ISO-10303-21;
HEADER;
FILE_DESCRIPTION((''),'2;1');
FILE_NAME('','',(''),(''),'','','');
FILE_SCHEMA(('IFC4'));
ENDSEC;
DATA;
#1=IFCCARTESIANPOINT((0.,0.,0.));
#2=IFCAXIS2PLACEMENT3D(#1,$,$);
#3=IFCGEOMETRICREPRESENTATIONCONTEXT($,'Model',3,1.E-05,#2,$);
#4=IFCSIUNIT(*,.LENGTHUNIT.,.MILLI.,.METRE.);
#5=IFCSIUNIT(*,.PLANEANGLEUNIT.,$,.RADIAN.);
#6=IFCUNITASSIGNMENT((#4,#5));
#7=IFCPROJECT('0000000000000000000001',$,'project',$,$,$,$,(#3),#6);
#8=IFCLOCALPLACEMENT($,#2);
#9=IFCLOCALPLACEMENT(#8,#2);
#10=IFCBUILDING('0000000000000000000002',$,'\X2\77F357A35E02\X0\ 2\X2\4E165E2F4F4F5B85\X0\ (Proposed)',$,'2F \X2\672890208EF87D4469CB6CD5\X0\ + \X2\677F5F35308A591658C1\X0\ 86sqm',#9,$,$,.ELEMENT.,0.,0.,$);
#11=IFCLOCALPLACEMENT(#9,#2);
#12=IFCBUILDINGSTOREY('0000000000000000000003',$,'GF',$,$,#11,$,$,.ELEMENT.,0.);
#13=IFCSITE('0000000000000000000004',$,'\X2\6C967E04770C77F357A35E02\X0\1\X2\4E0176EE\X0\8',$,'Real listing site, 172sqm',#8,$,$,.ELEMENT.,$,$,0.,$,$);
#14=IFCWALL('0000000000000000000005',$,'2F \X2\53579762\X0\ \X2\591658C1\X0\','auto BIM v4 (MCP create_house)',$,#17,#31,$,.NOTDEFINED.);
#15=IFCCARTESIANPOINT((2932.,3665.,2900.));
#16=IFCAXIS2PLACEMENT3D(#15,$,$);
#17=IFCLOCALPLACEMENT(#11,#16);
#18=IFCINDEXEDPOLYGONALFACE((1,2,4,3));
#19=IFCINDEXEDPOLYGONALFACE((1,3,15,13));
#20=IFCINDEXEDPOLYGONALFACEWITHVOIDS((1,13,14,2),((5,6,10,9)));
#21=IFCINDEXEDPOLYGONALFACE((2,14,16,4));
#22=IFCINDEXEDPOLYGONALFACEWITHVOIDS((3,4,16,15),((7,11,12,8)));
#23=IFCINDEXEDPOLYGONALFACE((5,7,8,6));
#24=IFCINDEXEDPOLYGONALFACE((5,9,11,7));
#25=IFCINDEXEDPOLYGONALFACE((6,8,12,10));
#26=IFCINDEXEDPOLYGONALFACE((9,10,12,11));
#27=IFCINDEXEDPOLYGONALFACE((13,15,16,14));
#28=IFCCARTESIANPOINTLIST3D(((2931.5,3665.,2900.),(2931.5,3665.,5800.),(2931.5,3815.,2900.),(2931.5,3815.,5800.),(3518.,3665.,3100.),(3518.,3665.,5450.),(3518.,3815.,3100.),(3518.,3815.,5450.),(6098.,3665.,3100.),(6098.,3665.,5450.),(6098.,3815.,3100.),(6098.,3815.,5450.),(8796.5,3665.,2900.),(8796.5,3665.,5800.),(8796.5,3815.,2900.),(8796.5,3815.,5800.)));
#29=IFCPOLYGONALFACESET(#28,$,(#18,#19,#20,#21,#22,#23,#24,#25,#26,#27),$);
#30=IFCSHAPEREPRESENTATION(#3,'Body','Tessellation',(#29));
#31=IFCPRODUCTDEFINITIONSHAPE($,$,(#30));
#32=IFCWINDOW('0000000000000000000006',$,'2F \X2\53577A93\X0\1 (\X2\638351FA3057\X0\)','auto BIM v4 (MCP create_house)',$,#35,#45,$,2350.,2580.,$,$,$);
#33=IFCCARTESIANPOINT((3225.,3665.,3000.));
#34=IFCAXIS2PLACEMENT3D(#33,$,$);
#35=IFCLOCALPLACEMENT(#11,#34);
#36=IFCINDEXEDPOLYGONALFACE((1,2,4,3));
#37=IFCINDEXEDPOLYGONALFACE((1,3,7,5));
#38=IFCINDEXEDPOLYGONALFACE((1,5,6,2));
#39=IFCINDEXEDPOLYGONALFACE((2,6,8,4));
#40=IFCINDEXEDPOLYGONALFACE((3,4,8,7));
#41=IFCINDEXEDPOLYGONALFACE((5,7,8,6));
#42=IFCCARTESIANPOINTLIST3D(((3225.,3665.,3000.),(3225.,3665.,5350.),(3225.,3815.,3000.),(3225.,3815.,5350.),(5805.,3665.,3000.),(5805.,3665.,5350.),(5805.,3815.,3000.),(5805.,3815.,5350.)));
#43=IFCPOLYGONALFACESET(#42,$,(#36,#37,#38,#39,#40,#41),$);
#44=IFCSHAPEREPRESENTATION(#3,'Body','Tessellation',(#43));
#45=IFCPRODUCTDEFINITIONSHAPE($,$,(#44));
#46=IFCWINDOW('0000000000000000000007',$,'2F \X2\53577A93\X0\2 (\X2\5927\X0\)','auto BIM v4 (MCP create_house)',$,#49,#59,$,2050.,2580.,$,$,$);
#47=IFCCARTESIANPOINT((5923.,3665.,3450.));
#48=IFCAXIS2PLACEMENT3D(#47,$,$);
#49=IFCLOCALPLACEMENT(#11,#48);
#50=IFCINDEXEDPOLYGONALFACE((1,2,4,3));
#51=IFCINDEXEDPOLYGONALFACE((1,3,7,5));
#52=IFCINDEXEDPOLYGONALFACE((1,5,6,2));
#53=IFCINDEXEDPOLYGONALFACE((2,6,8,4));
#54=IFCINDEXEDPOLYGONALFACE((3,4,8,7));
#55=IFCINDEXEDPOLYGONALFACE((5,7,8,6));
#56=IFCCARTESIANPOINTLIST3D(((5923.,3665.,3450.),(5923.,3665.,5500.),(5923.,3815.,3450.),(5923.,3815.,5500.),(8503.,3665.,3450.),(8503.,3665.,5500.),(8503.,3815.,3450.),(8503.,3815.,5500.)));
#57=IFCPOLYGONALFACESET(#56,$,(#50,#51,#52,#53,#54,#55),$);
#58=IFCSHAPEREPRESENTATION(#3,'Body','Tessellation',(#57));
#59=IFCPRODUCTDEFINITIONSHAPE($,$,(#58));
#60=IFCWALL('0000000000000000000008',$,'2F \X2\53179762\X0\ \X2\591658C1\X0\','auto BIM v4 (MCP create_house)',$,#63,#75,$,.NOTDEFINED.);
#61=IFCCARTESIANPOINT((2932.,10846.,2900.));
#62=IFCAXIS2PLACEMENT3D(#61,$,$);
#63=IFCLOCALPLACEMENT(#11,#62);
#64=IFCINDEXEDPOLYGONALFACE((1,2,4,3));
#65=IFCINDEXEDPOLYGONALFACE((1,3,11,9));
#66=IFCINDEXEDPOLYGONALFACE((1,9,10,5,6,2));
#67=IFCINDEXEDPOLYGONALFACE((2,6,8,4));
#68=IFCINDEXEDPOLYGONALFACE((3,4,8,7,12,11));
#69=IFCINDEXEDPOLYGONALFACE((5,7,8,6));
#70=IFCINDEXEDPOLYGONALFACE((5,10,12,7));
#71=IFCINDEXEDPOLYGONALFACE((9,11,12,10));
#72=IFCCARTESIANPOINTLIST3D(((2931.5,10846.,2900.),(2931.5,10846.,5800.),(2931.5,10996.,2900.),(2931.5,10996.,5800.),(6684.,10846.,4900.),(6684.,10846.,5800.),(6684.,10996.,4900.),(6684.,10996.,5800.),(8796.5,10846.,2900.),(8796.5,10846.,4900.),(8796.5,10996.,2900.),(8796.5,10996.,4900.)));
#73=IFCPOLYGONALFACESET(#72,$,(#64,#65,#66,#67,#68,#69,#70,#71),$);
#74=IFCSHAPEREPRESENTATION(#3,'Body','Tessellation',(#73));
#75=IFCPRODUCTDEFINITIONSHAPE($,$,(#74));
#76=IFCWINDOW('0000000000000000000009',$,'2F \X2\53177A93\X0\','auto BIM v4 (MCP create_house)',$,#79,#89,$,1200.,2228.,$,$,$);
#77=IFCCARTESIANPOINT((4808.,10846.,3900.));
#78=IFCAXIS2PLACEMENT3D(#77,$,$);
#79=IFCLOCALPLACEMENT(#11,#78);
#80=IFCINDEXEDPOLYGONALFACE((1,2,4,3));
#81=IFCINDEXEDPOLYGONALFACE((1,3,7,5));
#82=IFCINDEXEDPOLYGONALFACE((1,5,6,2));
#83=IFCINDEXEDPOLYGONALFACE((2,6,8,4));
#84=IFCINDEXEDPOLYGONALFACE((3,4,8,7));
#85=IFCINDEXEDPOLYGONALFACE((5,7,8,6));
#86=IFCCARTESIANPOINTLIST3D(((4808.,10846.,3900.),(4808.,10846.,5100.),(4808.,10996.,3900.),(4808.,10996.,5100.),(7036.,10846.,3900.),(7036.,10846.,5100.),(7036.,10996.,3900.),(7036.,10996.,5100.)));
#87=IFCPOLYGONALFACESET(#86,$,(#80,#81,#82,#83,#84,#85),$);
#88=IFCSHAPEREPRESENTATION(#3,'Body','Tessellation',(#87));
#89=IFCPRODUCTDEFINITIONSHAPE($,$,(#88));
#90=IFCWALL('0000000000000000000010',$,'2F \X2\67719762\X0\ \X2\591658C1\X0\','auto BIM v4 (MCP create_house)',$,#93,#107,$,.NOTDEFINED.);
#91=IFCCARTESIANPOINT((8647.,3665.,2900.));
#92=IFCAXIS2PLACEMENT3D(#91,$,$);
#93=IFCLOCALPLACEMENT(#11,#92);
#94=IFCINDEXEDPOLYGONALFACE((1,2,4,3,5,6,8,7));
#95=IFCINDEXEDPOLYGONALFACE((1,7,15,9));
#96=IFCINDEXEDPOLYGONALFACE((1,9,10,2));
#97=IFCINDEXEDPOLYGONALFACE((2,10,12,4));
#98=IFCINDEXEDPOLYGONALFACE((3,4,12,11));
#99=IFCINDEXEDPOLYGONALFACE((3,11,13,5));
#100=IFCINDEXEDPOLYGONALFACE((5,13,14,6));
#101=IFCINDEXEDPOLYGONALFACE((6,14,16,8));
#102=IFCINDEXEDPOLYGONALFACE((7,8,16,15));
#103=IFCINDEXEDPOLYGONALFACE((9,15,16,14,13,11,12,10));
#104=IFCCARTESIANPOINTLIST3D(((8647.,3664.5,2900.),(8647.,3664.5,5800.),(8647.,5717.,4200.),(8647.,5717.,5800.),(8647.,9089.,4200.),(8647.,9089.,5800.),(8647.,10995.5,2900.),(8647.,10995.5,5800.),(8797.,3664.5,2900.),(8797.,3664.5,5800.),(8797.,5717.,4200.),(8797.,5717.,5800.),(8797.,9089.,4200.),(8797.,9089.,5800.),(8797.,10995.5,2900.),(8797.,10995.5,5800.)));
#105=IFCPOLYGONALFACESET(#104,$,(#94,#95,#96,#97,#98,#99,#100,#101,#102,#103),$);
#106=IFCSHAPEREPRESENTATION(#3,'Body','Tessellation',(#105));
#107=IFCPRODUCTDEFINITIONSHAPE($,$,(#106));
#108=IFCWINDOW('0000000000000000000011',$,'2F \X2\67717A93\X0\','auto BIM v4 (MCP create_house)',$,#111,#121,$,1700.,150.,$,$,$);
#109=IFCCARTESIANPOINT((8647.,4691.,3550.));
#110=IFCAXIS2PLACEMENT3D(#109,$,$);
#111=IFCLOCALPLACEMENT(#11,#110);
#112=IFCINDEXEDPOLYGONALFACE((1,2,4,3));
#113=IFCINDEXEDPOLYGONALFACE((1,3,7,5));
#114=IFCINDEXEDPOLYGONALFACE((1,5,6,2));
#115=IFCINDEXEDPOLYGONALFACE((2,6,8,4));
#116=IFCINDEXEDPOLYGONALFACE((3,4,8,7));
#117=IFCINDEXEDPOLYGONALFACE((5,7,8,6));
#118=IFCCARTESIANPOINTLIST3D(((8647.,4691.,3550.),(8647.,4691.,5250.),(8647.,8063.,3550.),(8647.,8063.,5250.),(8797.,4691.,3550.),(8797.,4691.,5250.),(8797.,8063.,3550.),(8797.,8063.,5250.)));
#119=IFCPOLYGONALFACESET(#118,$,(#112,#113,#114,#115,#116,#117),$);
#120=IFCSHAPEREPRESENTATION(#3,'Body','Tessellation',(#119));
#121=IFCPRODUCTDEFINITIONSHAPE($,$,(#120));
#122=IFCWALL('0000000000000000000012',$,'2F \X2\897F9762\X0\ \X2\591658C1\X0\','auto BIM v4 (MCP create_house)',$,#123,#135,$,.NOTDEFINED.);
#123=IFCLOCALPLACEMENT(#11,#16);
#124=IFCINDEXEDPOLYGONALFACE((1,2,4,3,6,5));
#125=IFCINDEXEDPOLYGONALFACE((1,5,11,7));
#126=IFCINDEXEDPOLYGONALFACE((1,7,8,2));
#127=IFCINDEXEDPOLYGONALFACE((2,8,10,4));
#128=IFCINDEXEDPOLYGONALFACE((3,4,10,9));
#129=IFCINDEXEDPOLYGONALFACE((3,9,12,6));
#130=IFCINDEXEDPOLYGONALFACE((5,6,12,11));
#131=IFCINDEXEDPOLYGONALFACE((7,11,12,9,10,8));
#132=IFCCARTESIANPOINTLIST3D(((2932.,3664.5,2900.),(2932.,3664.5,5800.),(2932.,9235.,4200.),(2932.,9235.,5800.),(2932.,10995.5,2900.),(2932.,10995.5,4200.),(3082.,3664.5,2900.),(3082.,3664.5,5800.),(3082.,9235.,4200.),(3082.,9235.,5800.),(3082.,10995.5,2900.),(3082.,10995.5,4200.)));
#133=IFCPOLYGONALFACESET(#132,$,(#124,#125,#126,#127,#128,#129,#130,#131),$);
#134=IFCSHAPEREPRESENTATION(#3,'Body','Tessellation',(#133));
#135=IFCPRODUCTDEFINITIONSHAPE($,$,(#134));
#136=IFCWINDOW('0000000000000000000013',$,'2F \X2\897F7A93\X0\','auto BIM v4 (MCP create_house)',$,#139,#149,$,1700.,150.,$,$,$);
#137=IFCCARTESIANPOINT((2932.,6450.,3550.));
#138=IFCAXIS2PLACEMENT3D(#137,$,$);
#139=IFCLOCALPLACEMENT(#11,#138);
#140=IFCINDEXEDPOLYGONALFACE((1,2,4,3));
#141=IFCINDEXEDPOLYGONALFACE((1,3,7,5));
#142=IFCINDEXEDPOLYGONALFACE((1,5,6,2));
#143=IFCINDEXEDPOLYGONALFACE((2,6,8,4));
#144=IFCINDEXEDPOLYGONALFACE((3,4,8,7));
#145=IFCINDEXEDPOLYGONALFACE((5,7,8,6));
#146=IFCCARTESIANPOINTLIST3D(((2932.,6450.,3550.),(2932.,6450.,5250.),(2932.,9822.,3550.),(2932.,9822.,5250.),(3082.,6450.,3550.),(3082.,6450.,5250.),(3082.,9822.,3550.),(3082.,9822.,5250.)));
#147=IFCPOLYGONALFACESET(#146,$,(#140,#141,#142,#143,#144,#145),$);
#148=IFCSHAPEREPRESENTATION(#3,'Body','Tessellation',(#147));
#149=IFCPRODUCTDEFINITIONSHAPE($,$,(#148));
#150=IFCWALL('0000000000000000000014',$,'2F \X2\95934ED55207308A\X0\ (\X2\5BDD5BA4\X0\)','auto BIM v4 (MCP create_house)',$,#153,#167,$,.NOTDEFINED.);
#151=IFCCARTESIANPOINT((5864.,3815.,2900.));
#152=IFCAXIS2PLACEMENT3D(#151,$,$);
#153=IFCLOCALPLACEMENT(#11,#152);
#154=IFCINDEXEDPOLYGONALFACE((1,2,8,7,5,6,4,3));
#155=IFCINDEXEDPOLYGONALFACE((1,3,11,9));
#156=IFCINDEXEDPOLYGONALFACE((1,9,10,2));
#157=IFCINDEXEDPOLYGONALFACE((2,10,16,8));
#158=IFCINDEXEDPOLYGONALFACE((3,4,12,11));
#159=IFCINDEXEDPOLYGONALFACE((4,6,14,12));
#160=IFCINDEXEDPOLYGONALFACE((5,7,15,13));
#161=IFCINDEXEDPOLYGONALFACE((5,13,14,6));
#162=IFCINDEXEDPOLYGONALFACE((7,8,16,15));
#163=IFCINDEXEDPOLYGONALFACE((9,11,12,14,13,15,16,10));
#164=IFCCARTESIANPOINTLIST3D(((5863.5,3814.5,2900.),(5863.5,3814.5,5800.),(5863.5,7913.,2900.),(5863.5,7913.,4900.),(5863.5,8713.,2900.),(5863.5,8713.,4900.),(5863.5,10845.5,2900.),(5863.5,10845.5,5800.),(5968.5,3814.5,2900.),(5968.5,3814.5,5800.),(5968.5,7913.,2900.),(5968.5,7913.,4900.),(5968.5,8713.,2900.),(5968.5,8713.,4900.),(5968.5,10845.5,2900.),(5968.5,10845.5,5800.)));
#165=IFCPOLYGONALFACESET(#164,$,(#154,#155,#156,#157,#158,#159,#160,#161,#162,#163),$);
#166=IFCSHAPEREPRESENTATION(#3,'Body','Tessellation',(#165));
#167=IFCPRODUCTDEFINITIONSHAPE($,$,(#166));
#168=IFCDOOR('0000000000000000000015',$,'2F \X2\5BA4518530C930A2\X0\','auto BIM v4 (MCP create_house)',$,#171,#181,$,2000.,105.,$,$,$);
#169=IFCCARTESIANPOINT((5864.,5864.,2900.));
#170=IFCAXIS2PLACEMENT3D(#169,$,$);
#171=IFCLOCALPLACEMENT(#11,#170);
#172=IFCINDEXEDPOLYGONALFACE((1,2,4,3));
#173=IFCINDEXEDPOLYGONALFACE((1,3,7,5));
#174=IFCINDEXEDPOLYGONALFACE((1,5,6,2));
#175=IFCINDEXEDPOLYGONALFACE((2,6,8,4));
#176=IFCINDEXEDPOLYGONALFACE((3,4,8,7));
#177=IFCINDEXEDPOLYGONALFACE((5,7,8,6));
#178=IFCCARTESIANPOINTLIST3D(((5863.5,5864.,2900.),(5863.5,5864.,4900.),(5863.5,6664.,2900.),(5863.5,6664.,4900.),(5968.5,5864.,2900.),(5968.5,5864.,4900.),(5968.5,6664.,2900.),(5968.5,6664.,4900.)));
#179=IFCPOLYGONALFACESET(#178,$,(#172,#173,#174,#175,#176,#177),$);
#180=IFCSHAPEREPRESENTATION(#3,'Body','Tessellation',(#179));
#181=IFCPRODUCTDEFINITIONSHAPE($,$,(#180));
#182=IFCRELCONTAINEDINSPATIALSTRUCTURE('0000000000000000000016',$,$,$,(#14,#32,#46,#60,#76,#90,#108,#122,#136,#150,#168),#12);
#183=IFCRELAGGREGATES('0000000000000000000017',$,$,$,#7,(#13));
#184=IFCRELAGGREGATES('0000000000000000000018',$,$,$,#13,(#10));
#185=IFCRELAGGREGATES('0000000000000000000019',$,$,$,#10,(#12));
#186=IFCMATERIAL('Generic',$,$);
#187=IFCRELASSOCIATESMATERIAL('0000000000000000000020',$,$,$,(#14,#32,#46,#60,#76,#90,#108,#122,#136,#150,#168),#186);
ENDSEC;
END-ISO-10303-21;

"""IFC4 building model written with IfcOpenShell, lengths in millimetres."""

from ifc_helpers import new_model, si_unit, frame, frame_2d, origin, place, context, project, spatial, rectangle, extrude, material, element, fill, save


model = new_model("IFC4")

# Units and contexts
model_context = context("Model", 3, precision=1e-05, world=origin())
ifc_project = project(units=[si_unit("LENGTHUNIT", "METRE", prefix="MILLI"), si_unit("PLANEANGLEUNIT", "RADIAN")], contexts=[model_context])

# Site, building, storey
site_placement = place(None, origin())
site = spatial("IfcSite", under=ifc_project, at=site_placement, Name="沖縄県石垣市1丁目8", ObjectType="Real listing site, 172sqm", CompositionType="ELEMENT", RefElevation=0.0)
building_placement = place(site_placement, origin())
building = spatial("IfcBuilding", under=site, at=building_placement, Name="石垣市 2世帯住宅 (Proposed)", ObjectType="2F 木造軸組構法 + 板張り外壁 86sqm", CompositionType="ELEMENT", ElevationOfRefHeight=0.0, ElevationOfTerrain=0.0)
storey_placement = place(building_placement, origin())
storey = spatial("IfcBuildingStorey", under=building, at=storey_placement, Name="GF", CompositionType="ELEMENT", Elevation=0.0)

# Shared definitions
ifc_material = material(Name="Generic")

# Wall, openings, windows
wall_1_placement = place(storey_placement, frame((2932.0, 3665.0, 2900.0)))
wall_1 = element("IfcWall", 1, at=wall_1_placement, inside=storey, material=ifc_material, Name="2F 南面 外壁", Description="auto BIM v4 (MCP create_house)", PredefinedType="NOTDEFINED", context=model_context, shape_type="SweptSolid", body=[
    extrude(rectangle(XDim=5865.0, YDim=150.0, at=frame_2d((2932.0, 75.0))), frame((2932.0, 3665.0, 2900.0)), (0.0, 0.0, 1.0), 2900.0),
])
opening_1_placement = place(storey_placement, frame((3225.0, 3665.0, 3000.0)))
opening_1 = element("IfcOpeningElement", 2, at=opening_1_placement, cuts=wall_1, PredefinedType="NOTDEFINED", context=model_context, shape_type="SweptSolid", body=[
    extrude(rectangle(XDim=2580.0, YDim=150.0, at=frame_2d((1290.0, 75.0))), frame((3225.0, 3665.0, 3000.0)), (0.0, 0.0, 1.0), 2350.0),
])
opening_2_placement = place(storey_placement, frame((5923.0, 3665.0, 3450.0)))
opening_2 = element("IfcOpeningElement", 3, at=opening_2_placement, cuts=wall_1, PredefinedType="NOTDEFINED", context=model_context, shape_type="SweptSolid", body=[
    extrude(rectangle(XDim=2580.0, YDim=150.0, at=frame_2d((1290.0, 75.0))), frame((5923.0, 3665.0, 3450.0)), (0.0, 0.0, 1.0), 2050.0),
])
window_1_placement = place(storey_placement, frame((3225.0, 3665.0, 3000.0)))
window_1 = element("IfcWindow", 4, at=window_1_placement, inside=storey, material=ifc_material, Name="2F 南窓1 (掃出し)", Description="auto BIM v4 (MCP create_house)", OverallHeight=2350.0, OverallWidth=2580.0, context=model_context, shape_type="SweptSolid", body=[
    extrude(rectangle(XDim=2580.0, YDim=150.0, at=frame_2d((1290.0, 75.0))), frame((3225.0, 3665.0, 3000.0)), (0.0, 0.0, 1.0), 2350.0),
])
fill(opening_1, window_1)
window_2_placement = place(storey_placement, frame((5923.0, 3665.0, 3450.0)))
window_2 = element("IfcWindow", 5, at=window_2_placement, inside=storey, material=ifc_material, Name="2F 南窓2 (大)", Description="auto BIM v4 (MCP create_house)", OverallHeight=2050.0, OverallWidth=2580.0, context=model_context, shape_type="SweptSolid", body=[
    extrude(rectangle(XDim=2580.0, YDim=150.0, at=frame_2d((1290.0, 75.0))), frame((5923.0, 3665.0, 3450.0)), (0.0, 0.0, 1.0), 2050.0),
])
fill(opening_2, window_2)

# Walls, openings, windows
wall_2_placement = place(storey_placement, frame((2932.0, 10846.0, 2900.0)))
wall_2 = element("IfcWall", 6, at=wall_2_placement, inside=storey, material=ifc_material, Name="2F 北面 外壁", Description="auto BIM v4 (MCP create_house)", PredefinedType="NOTDEFINED", context=model_context, shape_type="SweptSolid", body=[
    extrude(rectangle(XDim=5865.0, YDim=150.0, at=frame_2d((2932.0, 75.0))), frame((2932.0, 10846.0, 2900.0)), (0.0, 0.0, 1.0), 2900.0),
])
opening_3_placement = place(storey_placement, frame((4808.0, 10846.0, 3900.0)))
opening_3 = element("IfcOpeningElement", 7, at=opening_3_placement, cuts=wall_2, PredefinedType="NOTDEFINED", context=model_context, shape_type="SweptSolid", body=[
    extrude(rectangle(XDim=2228.0, YDim=150.0, at=frame_2d((1114.0, 75.0))), frame((4808.0, 10846.0, 3900.0)), (0.0, 0.0, 1.0), 1200.0),
])
window_3_placement = place(storey_placement, frame((4808.0, 10846.0, 3900.0)))
window_3 = element("IfcWindow", 8, at=window_3_placement, inside=storey, material=ifc_material, Name="2F 北窓", Description="auto BIM v4 (MCP create_house)", OverallHeight=1200.0, OverallWidth=2228.0, context=model_context, shape_type="SweptSolid", body=[
    extrude(rectangle(XDim=2228.0, YDim=150.0, at=frame_2d((1114.0, 75.0))), frame((4808.0, 10846.0, 3900.0)), (0.0, 0.0, 1.0), 1200.0),
])
fill(opening_3, window_3)
wall_3_placement = place(storey_placement, frame((8647.0, 3665.0, 2900.0)))
wall_3 = element("IfcWall", 9, at=wall_3_placement, inside=storey, material=ifc_material, Name="2F 東面 外壁", Description="auto BIM v4 (MCP create_house)", PredefinedType="NOTDEFINED", context=model_context, shape_type="SweptSolid", body=[
    extrude(rectangle(XDim=150.0, YDim=7331.0, at=frame_2d((75.0, 3665.0))), frame((8647.0, 3665.0, 2900.0)), (0.0, 0.0, 1.0), 2900.0),
])
opening_4_placement = place(storey_placement, frame((8647.0, 4691.0, 3550.0)))
opening_4 = element("IfcOpeningElement", 10, at=opening_4_placement, cuts=wall_3, PredefinedType="NOTDEFINED", context=model_context, shape_type="SweptSolid", body=[
    extrude(rectangle(XDim=150.0, YDim=3372.0, at=frame_2d((75.0, 1686.0))), frame((8647.0, 4691.0, 3550.0)), (0.0, 0.0, 1.0), 1700.0),
])
window_4_placement = place(storey_placement, frame((8647.0, 4691.0, 3550.0)))
window_4 = element("IfcWindow", 11, at=window_4_placement, inside=storey, material=ifc_material, Name="2F 東窓", Description="auto BIM v4 (MCP create_house)", OverallHeight=1700.0, OverallWidth=150.0, context=model_context, shape_type="SweptSolid", body=[
    extrude(rectangle(XDim=150.0, YDim=3372.0, at=frame_2d((75.0, 1686.0))), frame((8647.0, 4691.0, 3550.0)), (0.0, 0.0, 1.0), 1700.0),
])
fill(opening_4, window_4)
wall_4_placement = place(storey_placement, frame((2932.0, 3665.0, 2900.0)))
wall_4 = element("IfcWall", 12, at=wall_4_placement, inside=storey, material=ifc_material, Name="2F 西面 外壁", Description="auto BIM v4 (MCP create_house)", PredefinedType="NOTDEFINED", context=model_context, shape_type="SweptSolid", body=[
    extrude(rectangle(XDim=150.0, YDim=7331.0, at=frame_2d((75.0, 3665.0))), frame((2932.0, 3665.0, 2900.0)), (0.0, 0.0, 1.0), 2900.0),
])
opening_5_placement = place(storey_placement, frame((2932.0, 6450.0, 3550.0)))
opening_5 = element("IfcOpeningElement", 13, at=opening_5_placement, cuts=wall_4, PredefinedType="NOTDEFINED", context=model_context, shape_type="SweptSolid", body=[
    extrude(rectangle(XDim=150.0, YDim=3372.0, at=frame_2d((75.0, 1686.0))), frame((2932.0, 6450.0, 3550.0)), (0.0, 0.0, 1.0), 1700.0),
])
window_5_placement = place(storey_placement, frame((2932.0, 6450.0, 3550.0)))
window_5 = element("IfcWindow", 14, at=window_5_placement, inside=storey, material=ifc_material, Name="2F 西窓", Description="auto BIM v4 (MCP create_house)", OverallHeight=1700.0, OverallWidth=150.0, context=model_context, shape_type="SweptSolid", body=[
    extrude(rectangle(XDim=150.0, YDim=3372.0, at=frame_2d((75.0, 1686.0))), frame((2932.0, 6450.0, 3550.0)), (0.0, 0.0, 1.0), 1700.0),
])
fill(opening_5, window_5)

# Wall, opening, door
wall_5_placement = place(storey_placement, frame((5864.0, 3815.0, 2900.0)))
wall_5 = element("IfcWall", 15, at=wall_5_placement, inside=storey, material=ifc_material, Name="2F 間仕切り (寝室)", Description="auto BIM v4 (MCP create_house)", PredefinedType="NOTDEFINED", context=model_context, shape_type="SweptSolid", body=[
    extrude(rectangle(XDim=105.0, YDim=7031.0, at=frame_2d((52.0, 3515.0))), frame((5864.0, 3815.0, 2900.0)), (0.0, 0.0, 1.0), 2900.0),
])
opening_6_placement = place(storey_placement, frame((5864.0, 5864.0, 2900.0)))
opening_6 = element("IfcOpeningElement", 16, at=opening_6_placement, cuts=wall_5, PredefinedType="NOTDEFINED", context=model_context, shape_type="SweptSolid", body=[
    extrude(rectangle(XDim=105.0, YDim=800.0, at=frame_2d((52.0, 400.0))), frame((5864.0, 5864.0, 2900.0)), (0.0, 0.0, 1.0), 2000.0),
])
door_1_placement = place(storey_placement, frame((5864.0, 5864.0, 2900.0)))
door_1 = element("IfcDoor", 17, at=door_1_placement, inside=storey, material=ifc_material, Name="2F 室内ドア", Description="auto BIM v4 (MCP create_house)", OverallHeight=2000.0, OverallWidth=105.0, context=model_context, shape_type="SweptSolid", body=[
    extrude(rectangle(XDim=105.0, YDim=800.0, at=frame_2d((52.0, 400.0))), frame((5864.0, 5864.0, 2900.0)), (0.0, 0.0, 1.0), 2000.0),
])
fill(opening_6, door_1)

save(model, "model.ifc")
